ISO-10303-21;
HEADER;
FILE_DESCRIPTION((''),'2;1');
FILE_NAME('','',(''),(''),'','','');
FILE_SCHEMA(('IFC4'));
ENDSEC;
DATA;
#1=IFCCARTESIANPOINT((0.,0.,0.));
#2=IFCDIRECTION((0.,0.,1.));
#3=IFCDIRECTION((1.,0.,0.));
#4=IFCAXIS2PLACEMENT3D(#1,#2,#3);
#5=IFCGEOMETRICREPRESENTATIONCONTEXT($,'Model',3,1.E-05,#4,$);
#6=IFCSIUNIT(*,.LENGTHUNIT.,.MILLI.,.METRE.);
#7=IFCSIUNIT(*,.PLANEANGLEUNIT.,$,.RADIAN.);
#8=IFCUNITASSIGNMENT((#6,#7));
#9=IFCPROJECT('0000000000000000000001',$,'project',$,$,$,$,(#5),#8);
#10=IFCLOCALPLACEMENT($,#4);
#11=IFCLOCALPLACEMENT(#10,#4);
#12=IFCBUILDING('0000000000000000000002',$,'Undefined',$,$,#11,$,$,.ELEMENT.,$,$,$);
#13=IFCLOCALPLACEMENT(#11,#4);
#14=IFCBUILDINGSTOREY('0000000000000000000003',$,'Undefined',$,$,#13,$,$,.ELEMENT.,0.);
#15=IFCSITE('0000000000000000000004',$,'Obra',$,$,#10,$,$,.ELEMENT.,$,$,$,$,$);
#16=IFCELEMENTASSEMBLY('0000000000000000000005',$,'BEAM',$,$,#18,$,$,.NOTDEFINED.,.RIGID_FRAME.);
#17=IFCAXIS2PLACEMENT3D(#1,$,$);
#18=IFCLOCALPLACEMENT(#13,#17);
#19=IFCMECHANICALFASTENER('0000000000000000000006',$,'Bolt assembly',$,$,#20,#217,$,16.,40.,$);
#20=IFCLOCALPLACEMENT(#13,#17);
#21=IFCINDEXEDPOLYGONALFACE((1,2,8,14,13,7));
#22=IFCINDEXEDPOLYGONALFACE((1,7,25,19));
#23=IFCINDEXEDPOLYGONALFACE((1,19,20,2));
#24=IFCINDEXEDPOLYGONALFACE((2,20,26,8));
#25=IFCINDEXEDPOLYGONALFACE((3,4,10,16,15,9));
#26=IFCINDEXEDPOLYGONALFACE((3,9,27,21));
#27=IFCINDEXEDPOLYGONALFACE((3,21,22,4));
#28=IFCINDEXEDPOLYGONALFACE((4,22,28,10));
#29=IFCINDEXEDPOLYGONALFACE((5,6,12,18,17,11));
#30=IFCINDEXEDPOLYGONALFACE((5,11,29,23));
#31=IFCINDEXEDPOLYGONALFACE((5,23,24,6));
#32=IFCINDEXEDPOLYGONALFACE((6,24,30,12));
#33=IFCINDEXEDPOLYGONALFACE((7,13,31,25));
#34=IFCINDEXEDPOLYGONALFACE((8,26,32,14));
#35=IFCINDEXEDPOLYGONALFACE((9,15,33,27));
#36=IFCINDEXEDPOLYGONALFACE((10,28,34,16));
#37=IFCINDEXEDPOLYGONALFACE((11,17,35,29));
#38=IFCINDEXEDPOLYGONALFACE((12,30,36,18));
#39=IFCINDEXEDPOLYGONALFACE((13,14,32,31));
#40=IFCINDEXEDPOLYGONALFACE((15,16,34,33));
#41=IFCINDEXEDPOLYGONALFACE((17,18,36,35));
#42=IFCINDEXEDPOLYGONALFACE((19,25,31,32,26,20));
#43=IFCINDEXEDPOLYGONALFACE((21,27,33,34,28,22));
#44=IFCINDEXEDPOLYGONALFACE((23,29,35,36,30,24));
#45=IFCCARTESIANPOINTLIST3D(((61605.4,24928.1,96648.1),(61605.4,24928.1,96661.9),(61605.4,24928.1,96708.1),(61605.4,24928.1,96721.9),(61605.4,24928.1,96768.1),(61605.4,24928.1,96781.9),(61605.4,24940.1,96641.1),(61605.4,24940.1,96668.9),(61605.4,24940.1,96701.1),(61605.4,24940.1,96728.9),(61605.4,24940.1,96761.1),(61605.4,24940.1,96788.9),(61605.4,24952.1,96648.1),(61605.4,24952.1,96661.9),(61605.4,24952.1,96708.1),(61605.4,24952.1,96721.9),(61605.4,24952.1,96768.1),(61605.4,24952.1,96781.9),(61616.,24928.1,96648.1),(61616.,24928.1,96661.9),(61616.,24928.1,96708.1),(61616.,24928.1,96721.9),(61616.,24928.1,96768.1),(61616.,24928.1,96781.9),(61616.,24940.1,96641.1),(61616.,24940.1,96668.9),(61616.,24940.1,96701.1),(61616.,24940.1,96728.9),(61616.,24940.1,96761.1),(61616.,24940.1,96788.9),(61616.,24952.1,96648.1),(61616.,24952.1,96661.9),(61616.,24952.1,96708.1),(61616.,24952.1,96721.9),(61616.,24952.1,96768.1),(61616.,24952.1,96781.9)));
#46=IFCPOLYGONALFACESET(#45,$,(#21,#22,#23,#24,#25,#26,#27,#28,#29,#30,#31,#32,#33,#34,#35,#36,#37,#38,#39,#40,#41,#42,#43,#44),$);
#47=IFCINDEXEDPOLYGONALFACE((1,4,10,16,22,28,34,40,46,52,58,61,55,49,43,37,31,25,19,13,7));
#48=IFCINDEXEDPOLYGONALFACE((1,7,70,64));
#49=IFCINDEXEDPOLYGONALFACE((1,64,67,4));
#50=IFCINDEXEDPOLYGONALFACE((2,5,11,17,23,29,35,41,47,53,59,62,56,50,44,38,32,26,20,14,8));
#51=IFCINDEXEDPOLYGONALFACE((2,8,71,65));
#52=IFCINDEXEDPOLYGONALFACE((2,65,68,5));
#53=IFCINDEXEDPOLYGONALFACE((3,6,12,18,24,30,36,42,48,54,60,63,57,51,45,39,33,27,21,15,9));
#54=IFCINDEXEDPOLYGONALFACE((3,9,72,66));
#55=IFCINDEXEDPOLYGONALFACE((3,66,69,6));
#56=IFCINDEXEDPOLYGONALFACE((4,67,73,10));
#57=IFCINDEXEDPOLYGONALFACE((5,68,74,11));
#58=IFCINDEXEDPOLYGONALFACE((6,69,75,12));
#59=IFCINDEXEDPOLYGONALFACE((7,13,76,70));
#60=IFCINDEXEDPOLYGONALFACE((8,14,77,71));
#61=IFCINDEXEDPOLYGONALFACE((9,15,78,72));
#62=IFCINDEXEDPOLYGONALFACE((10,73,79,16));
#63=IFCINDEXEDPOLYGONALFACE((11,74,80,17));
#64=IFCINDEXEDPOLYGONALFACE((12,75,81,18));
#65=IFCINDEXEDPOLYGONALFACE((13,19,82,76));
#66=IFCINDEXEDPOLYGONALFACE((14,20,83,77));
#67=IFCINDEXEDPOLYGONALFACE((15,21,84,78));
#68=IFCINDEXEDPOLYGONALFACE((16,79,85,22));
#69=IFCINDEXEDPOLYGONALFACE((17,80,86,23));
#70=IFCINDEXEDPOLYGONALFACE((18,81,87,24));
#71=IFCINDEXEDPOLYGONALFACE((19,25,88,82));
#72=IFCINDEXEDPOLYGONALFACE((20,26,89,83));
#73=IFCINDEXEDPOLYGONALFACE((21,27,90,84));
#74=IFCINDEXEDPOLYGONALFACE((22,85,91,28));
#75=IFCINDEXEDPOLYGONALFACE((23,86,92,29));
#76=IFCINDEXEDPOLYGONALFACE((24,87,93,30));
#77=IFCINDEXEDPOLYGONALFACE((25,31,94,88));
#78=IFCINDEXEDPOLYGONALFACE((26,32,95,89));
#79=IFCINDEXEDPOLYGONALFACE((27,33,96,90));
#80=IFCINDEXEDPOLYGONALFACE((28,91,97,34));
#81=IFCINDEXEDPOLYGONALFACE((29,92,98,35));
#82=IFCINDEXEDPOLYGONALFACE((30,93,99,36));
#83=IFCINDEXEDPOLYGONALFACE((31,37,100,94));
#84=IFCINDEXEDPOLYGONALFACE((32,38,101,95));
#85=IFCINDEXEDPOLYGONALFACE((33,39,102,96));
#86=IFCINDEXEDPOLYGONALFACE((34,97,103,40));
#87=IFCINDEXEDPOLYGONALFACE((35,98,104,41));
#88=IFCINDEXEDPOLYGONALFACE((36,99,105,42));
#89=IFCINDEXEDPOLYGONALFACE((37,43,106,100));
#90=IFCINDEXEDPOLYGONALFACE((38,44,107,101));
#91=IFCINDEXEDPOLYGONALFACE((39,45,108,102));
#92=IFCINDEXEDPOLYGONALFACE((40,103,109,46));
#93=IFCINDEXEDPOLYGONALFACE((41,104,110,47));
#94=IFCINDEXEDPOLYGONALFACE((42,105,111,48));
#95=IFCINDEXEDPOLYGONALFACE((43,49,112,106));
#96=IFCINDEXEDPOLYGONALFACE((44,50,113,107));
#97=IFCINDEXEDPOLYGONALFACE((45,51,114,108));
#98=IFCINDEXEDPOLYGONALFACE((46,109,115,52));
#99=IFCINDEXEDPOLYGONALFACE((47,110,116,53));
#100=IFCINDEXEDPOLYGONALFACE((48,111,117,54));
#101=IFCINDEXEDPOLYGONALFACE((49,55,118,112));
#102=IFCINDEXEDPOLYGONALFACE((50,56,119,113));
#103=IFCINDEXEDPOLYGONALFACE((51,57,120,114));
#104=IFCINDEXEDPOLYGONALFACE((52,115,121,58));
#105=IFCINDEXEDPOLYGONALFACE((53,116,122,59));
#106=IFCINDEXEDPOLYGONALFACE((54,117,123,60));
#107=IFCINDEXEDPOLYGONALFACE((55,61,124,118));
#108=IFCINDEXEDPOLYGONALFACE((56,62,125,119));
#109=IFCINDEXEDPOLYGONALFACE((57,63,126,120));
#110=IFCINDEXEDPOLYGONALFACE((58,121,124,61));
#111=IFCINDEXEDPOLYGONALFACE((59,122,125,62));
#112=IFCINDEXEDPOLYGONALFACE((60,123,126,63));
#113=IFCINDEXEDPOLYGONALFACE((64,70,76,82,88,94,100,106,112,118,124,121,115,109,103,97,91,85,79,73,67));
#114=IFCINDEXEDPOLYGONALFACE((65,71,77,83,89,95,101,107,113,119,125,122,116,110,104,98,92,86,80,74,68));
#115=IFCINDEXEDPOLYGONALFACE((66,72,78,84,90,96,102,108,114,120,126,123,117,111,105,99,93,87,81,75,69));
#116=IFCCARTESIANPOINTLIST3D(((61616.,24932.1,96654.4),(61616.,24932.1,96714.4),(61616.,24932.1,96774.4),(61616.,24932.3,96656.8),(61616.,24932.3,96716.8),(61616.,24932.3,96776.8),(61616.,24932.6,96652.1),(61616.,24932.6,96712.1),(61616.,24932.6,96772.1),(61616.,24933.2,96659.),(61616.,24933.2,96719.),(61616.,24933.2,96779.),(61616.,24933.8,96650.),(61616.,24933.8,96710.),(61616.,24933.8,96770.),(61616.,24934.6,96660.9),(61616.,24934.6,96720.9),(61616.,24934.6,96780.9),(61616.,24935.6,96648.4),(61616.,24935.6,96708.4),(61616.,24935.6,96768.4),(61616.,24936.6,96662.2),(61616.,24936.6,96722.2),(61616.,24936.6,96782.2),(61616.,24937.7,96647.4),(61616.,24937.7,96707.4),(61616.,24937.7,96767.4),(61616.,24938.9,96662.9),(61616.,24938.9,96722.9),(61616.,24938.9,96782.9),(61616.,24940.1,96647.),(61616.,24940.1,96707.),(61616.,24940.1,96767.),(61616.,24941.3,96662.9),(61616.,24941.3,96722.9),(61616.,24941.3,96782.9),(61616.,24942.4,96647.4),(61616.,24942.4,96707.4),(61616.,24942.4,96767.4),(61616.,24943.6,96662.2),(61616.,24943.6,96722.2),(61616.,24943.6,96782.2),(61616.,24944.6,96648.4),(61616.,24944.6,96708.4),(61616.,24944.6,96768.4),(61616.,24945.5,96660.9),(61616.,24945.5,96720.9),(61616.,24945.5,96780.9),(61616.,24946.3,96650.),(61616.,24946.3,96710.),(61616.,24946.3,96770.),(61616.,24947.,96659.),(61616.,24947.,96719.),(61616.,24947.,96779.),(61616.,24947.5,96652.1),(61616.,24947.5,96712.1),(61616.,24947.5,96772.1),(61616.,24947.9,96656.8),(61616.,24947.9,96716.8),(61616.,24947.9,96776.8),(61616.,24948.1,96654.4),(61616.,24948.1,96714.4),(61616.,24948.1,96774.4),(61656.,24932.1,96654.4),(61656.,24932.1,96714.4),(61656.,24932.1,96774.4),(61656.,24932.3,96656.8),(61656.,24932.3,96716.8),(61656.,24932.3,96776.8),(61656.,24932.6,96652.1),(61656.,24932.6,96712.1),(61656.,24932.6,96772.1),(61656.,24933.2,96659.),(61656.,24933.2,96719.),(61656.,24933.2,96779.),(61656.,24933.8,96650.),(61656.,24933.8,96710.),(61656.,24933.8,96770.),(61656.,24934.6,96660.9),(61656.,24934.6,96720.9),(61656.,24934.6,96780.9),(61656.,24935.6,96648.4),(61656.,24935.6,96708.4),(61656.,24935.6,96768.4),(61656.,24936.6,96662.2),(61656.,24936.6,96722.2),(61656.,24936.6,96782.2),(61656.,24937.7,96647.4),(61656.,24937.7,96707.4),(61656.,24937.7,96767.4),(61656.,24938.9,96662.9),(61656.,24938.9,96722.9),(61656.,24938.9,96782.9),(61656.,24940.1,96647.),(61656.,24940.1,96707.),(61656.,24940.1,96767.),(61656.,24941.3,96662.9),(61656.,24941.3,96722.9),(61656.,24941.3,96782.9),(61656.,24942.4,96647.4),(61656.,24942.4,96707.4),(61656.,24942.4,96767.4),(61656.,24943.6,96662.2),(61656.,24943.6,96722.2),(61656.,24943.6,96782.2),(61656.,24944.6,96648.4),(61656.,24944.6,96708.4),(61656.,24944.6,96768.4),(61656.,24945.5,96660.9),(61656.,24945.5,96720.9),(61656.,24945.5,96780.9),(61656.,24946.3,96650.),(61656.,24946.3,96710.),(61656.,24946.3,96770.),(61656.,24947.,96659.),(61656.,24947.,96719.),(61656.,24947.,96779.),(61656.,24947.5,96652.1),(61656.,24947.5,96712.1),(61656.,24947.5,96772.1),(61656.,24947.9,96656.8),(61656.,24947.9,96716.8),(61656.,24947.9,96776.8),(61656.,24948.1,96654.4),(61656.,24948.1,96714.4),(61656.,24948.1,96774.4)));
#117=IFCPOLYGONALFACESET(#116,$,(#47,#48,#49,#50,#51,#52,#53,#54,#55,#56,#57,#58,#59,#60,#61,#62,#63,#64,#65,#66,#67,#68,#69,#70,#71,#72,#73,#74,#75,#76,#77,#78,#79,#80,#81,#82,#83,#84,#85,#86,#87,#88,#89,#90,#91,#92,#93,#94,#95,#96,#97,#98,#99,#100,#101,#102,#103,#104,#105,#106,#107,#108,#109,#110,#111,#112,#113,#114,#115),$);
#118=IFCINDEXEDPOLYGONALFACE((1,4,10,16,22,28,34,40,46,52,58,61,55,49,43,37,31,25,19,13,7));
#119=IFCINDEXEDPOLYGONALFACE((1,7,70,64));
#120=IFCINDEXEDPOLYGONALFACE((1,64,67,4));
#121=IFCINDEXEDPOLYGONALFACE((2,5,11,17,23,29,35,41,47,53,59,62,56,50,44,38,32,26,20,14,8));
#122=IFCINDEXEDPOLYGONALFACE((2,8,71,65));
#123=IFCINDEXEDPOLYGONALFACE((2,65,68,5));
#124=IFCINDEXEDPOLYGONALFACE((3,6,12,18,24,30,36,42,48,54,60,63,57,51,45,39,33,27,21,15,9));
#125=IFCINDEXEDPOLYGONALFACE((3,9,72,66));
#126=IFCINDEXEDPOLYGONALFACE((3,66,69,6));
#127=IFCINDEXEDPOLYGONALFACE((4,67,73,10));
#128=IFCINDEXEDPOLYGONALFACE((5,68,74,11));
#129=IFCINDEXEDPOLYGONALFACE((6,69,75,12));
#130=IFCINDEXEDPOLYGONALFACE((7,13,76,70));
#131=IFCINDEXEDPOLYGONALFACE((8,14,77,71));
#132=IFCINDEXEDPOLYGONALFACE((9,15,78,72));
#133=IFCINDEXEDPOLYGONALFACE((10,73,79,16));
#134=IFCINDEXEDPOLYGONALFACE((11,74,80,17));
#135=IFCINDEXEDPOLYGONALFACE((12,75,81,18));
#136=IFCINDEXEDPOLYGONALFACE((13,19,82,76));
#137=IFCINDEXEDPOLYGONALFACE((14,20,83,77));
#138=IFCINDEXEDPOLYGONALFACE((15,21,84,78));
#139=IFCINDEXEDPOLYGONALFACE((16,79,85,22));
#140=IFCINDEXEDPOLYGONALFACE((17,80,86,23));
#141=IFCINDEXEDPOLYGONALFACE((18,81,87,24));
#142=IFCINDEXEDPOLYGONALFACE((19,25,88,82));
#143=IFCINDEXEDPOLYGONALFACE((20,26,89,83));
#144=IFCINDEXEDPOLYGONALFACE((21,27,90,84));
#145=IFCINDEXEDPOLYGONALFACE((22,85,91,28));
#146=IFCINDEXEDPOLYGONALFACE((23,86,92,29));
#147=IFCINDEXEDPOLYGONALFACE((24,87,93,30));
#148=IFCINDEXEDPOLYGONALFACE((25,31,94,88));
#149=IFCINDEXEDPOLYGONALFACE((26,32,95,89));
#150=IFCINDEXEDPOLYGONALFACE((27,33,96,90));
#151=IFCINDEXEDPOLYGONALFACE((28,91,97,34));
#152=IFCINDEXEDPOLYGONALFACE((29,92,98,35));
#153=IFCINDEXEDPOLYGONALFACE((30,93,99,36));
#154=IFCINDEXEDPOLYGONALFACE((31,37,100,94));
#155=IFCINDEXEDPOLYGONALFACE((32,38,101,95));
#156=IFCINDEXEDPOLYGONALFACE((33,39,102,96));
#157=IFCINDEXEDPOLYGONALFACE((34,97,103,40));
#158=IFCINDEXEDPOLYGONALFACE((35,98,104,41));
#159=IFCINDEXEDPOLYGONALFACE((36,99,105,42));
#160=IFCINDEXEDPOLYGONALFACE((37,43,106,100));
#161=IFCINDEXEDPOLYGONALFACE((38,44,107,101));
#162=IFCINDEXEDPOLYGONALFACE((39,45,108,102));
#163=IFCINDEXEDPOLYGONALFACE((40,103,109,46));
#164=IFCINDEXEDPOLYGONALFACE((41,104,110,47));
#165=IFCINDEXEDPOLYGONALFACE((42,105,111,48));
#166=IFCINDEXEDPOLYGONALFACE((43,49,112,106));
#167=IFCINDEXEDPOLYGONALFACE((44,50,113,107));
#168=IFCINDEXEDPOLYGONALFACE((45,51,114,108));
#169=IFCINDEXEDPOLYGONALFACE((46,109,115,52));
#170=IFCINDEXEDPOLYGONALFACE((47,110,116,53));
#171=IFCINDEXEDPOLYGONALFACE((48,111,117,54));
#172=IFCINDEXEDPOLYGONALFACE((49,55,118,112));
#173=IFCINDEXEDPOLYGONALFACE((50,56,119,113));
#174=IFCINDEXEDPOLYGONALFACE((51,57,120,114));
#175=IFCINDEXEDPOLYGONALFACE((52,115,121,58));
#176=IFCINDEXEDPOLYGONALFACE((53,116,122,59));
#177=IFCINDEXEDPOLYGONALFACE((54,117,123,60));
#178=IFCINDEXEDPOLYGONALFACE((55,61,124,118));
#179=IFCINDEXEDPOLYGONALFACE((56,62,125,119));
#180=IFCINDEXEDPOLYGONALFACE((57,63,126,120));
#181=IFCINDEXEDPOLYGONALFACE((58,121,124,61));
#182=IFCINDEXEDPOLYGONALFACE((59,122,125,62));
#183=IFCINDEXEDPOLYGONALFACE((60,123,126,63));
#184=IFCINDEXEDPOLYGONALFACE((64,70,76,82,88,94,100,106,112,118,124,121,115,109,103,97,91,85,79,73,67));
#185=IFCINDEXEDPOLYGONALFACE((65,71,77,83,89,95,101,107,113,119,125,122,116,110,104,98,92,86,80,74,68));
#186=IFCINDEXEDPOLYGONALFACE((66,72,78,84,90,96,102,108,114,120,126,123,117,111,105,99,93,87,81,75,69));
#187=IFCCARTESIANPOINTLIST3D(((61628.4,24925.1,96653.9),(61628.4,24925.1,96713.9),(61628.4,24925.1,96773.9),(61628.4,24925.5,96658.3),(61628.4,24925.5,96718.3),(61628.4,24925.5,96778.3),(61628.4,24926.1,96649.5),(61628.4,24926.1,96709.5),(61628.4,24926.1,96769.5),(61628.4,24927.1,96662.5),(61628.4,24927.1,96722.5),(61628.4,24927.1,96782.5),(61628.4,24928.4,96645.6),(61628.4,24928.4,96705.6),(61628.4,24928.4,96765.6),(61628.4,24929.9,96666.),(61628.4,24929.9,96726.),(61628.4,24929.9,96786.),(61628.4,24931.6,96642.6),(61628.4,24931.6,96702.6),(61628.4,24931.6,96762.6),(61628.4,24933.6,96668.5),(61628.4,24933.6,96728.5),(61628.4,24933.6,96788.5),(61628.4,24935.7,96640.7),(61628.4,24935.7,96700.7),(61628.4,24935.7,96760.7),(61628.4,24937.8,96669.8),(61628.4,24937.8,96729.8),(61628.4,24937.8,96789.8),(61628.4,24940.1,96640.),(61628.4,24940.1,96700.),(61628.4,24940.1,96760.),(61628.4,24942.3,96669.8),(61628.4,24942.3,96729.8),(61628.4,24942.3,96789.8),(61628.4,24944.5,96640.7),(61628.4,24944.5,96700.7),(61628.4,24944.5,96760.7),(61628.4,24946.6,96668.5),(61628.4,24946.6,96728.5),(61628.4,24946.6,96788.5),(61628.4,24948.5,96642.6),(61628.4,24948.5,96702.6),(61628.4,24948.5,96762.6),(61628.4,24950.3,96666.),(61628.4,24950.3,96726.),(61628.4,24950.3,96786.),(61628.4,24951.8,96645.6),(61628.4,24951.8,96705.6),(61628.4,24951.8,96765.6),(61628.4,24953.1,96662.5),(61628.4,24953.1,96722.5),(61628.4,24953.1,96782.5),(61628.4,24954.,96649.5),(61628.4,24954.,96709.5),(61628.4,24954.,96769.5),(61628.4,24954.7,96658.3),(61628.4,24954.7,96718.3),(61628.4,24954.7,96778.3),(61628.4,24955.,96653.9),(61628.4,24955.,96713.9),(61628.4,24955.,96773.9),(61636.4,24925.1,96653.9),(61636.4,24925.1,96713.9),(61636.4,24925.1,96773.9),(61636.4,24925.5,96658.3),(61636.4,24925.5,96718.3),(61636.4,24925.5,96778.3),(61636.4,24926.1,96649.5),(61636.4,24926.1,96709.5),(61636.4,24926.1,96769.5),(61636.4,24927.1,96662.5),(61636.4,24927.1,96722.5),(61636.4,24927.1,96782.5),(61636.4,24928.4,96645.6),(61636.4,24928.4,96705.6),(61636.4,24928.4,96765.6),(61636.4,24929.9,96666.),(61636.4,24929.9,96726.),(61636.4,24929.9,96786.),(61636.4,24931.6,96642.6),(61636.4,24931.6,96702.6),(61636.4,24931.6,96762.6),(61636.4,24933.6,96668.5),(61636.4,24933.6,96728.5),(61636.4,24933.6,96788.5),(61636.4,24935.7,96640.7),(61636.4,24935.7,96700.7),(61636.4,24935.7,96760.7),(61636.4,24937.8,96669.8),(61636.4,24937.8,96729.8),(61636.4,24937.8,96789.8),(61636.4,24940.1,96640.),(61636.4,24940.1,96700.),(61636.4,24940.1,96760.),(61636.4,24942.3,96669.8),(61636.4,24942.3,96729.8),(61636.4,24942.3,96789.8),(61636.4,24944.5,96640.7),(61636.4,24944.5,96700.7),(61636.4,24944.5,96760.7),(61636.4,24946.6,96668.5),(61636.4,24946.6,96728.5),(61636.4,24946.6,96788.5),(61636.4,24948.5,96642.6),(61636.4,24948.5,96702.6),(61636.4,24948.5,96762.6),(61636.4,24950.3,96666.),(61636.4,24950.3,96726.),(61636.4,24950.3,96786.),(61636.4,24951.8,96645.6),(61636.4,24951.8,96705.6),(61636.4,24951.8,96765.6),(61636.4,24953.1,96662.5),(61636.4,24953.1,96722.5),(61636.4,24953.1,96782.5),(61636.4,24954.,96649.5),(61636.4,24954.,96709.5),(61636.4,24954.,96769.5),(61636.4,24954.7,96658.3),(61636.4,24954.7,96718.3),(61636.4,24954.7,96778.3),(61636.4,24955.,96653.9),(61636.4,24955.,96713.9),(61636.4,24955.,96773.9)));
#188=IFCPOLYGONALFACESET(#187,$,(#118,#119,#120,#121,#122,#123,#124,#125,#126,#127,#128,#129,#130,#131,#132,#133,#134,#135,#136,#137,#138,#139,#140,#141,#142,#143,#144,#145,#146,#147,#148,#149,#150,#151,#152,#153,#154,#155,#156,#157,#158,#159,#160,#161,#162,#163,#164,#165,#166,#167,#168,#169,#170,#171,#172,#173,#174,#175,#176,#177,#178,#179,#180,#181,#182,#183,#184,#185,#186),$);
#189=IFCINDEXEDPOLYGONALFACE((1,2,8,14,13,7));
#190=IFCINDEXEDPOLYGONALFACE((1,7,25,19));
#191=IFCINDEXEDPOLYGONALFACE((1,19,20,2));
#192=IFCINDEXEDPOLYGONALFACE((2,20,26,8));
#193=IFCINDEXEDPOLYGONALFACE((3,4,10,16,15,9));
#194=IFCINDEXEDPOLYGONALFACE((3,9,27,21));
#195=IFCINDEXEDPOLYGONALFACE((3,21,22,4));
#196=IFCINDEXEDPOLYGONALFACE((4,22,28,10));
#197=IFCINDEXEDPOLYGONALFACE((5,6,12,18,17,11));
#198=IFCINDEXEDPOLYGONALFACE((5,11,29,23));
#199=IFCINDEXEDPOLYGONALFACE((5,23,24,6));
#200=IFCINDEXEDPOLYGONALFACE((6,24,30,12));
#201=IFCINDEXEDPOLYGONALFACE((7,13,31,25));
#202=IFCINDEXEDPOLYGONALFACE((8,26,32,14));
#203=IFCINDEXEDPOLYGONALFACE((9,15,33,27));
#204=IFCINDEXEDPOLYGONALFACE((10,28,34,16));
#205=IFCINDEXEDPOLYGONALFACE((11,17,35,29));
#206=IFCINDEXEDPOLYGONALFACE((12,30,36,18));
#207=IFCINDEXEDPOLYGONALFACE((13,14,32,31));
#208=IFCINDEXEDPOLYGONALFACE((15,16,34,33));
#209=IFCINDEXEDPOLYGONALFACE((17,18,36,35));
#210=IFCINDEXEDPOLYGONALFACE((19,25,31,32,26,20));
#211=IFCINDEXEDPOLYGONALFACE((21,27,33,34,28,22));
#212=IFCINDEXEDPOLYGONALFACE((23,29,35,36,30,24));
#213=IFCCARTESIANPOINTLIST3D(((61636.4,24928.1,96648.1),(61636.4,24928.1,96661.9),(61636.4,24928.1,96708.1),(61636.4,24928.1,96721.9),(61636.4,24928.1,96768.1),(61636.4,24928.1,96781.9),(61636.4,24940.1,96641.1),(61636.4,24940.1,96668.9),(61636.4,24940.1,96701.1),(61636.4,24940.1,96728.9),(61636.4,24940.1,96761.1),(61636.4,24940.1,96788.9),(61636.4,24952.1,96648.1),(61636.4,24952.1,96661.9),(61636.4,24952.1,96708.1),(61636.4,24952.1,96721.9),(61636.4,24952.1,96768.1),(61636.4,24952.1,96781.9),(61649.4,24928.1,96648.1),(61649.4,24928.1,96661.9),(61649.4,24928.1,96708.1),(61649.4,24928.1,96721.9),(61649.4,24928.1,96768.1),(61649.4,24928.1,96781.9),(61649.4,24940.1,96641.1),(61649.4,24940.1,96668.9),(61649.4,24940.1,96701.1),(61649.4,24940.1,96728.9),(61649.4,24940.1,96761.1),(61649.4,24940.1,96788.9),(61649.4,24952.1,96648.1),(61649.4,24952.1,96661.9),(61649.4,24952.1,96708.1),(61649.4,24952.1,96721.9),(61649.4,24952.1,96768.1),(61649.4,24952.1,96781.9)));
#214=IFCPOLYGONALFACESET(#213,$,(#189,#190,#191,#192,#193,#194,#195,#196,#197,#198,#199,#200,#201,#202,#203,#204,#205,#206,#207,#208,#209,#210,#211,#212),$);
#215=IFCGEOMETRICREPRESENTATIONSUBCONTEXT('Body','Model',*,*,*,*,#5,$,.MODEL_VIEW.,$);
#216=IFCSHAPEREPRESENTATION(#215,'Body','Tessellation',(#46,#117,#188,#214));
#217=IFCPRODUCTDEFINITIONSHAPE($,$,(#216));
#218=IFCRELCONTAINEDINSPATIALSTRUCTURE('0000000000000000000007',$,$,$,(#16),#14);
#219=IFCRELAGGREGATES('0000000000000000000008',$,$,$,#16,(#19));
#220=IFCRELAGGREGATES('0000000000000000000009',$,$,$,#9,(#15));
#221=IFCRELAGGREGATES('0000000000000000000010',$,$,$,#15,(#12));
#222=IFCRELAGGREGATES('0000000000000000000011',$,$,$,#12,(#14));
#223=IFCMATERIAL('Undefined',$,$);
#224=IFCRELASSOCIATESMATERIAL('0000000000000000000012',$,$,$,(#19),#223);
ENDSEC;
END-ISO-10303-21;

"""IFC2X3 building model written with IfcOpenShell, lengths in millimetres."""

from ifc_helpers import new_model, si_unit, frame, origin_with_axes, origin_2d_with_axis, place, context, subcontext, project, spatial, polyline, circle, outline, extrude, source, transform, mapped, material, element, aggregate, save


model = new_model("IFC2X3")

# Units and contexts
model_context = context("Model", 3, precision=1e-05, world=origin_with_axes())
body_context = subcontext(model_context, "Body", "Model", "MODEL_VIEW")
ifc_project = project(units=[si_unit("LENGTHUNIT", "METRE", prefix="MILLI"), si_unit("PLANEANGLEUNIT", "RADIAN")], contexts=[model_context])

# Site, building, storey
site_placement = place(None, origin_with_axes())
site = spatial("IfcSite", under=ifc_project, at=site_placement, Name="Obra", CompositionType="ELEMENT")
building_placement = place(site_placement, origin_with_axes())
building = spatial("IfcBuilding", under=site, at=building_placement, Name="Undefined", CompositionType="ELEMENT")
storey_placement = place(building_placement, origin_with_axes())
storey = spatial("IfcBuildingStorey", under=building, at=storey_placement, Name="Undefined", CompositionType="ELEMENT", Elevation=0.0)

# Shared definitions
ifc_material_1 = material(Name="Undefined")

# Element assembly, mechanical fastener
shared_shape_1 = source(origin_with_axes(), body_context, "Body", "SweptSolid", [
    extrude(outline(polyline([(13.9, 0.0), (6.9, 12.0), (-6.9, 12.0), (-13.9, 0.0), (-6.9, -12.0), (6.9, -12.0), (13.9, 0.0)])), frame((0.0, -19.7, 0.0), z_axis=(0.0, 1.0, 0.0), x_axis=(1.0, 0.0, 0.0)), (0.0, 0.0, 1.0), 10.6),
    extrude(circle(Radius=8.0, at=origin_2d_with_axis()), frame((0.0, -9.1, 0.0), z_axis=(0.0, 1.0, 0.0), x_axis=(1.0, 0.0, 0.0)), (0.0, 0.0, 1.0), 40.0),
    extrude(circle(Radius=15.0, at=origin_2d_with_axis()), frame((0.0, 3.3, 0.0), z_axis=(0.0, 1.0, 0.0), x_axis=(1.0, 0.0, 0.0)), (0.0, 0.0, 1.0), 8.0),
    extrude(outline(polyline([(13.9, 0.0), (6.9, 12.0), (-6.9, 12.0), (-13.9, 0.0), (-6.9, -12.0), (6.9, -12.0), (13.9, 0.0)])), frame((0.0, 11.3, 0.0), z_axis=(0.0, 1.0, 0.0), x_axis=(1.0, 0.0, 0.0)), (0.0, 0.0, 1.0), 13.0),
])
assembly_1_placement = place(storey_placement, origin_with_axes())
assembly_1 = element("IfcElementAssembly", 1, at=assembly_1_placement, inside=storey, Name="BEAM", AssemblyPlace="NOTDEFINED", PredefinedType="RIGID_FRAME")
mechanical_fastener_1_placement = place(assembly_1_placement, frame((61625.1, 24990.1, 96835.0), z_axis=(0.000002, -1.0, 0.0), x_axis=(0.0, 0.0, -1.0)))
mechanical_fastener_1 = element("IfcMechanicalFastener", 2, at=mechanical_fastener_1_placement, material=ifc_material_1, Name="Bolt assembly", NominalDiameter=16.0, NominalLength=40.0, context=body_context, shape_type="MappedRepresentation", body=[
    mapped(shared_shape_1, transform((60.0, 0.0, 50.0))),
    mapped(shared_shape_1, transform((120.0, 0.0, 50.0))),
    mapped(shared_shape_1, transform((180.0, 0.0, 50.0))),
])

aggregate(assembly_1, [mechanical_fastener_1])

save(model, "model.ifc")
